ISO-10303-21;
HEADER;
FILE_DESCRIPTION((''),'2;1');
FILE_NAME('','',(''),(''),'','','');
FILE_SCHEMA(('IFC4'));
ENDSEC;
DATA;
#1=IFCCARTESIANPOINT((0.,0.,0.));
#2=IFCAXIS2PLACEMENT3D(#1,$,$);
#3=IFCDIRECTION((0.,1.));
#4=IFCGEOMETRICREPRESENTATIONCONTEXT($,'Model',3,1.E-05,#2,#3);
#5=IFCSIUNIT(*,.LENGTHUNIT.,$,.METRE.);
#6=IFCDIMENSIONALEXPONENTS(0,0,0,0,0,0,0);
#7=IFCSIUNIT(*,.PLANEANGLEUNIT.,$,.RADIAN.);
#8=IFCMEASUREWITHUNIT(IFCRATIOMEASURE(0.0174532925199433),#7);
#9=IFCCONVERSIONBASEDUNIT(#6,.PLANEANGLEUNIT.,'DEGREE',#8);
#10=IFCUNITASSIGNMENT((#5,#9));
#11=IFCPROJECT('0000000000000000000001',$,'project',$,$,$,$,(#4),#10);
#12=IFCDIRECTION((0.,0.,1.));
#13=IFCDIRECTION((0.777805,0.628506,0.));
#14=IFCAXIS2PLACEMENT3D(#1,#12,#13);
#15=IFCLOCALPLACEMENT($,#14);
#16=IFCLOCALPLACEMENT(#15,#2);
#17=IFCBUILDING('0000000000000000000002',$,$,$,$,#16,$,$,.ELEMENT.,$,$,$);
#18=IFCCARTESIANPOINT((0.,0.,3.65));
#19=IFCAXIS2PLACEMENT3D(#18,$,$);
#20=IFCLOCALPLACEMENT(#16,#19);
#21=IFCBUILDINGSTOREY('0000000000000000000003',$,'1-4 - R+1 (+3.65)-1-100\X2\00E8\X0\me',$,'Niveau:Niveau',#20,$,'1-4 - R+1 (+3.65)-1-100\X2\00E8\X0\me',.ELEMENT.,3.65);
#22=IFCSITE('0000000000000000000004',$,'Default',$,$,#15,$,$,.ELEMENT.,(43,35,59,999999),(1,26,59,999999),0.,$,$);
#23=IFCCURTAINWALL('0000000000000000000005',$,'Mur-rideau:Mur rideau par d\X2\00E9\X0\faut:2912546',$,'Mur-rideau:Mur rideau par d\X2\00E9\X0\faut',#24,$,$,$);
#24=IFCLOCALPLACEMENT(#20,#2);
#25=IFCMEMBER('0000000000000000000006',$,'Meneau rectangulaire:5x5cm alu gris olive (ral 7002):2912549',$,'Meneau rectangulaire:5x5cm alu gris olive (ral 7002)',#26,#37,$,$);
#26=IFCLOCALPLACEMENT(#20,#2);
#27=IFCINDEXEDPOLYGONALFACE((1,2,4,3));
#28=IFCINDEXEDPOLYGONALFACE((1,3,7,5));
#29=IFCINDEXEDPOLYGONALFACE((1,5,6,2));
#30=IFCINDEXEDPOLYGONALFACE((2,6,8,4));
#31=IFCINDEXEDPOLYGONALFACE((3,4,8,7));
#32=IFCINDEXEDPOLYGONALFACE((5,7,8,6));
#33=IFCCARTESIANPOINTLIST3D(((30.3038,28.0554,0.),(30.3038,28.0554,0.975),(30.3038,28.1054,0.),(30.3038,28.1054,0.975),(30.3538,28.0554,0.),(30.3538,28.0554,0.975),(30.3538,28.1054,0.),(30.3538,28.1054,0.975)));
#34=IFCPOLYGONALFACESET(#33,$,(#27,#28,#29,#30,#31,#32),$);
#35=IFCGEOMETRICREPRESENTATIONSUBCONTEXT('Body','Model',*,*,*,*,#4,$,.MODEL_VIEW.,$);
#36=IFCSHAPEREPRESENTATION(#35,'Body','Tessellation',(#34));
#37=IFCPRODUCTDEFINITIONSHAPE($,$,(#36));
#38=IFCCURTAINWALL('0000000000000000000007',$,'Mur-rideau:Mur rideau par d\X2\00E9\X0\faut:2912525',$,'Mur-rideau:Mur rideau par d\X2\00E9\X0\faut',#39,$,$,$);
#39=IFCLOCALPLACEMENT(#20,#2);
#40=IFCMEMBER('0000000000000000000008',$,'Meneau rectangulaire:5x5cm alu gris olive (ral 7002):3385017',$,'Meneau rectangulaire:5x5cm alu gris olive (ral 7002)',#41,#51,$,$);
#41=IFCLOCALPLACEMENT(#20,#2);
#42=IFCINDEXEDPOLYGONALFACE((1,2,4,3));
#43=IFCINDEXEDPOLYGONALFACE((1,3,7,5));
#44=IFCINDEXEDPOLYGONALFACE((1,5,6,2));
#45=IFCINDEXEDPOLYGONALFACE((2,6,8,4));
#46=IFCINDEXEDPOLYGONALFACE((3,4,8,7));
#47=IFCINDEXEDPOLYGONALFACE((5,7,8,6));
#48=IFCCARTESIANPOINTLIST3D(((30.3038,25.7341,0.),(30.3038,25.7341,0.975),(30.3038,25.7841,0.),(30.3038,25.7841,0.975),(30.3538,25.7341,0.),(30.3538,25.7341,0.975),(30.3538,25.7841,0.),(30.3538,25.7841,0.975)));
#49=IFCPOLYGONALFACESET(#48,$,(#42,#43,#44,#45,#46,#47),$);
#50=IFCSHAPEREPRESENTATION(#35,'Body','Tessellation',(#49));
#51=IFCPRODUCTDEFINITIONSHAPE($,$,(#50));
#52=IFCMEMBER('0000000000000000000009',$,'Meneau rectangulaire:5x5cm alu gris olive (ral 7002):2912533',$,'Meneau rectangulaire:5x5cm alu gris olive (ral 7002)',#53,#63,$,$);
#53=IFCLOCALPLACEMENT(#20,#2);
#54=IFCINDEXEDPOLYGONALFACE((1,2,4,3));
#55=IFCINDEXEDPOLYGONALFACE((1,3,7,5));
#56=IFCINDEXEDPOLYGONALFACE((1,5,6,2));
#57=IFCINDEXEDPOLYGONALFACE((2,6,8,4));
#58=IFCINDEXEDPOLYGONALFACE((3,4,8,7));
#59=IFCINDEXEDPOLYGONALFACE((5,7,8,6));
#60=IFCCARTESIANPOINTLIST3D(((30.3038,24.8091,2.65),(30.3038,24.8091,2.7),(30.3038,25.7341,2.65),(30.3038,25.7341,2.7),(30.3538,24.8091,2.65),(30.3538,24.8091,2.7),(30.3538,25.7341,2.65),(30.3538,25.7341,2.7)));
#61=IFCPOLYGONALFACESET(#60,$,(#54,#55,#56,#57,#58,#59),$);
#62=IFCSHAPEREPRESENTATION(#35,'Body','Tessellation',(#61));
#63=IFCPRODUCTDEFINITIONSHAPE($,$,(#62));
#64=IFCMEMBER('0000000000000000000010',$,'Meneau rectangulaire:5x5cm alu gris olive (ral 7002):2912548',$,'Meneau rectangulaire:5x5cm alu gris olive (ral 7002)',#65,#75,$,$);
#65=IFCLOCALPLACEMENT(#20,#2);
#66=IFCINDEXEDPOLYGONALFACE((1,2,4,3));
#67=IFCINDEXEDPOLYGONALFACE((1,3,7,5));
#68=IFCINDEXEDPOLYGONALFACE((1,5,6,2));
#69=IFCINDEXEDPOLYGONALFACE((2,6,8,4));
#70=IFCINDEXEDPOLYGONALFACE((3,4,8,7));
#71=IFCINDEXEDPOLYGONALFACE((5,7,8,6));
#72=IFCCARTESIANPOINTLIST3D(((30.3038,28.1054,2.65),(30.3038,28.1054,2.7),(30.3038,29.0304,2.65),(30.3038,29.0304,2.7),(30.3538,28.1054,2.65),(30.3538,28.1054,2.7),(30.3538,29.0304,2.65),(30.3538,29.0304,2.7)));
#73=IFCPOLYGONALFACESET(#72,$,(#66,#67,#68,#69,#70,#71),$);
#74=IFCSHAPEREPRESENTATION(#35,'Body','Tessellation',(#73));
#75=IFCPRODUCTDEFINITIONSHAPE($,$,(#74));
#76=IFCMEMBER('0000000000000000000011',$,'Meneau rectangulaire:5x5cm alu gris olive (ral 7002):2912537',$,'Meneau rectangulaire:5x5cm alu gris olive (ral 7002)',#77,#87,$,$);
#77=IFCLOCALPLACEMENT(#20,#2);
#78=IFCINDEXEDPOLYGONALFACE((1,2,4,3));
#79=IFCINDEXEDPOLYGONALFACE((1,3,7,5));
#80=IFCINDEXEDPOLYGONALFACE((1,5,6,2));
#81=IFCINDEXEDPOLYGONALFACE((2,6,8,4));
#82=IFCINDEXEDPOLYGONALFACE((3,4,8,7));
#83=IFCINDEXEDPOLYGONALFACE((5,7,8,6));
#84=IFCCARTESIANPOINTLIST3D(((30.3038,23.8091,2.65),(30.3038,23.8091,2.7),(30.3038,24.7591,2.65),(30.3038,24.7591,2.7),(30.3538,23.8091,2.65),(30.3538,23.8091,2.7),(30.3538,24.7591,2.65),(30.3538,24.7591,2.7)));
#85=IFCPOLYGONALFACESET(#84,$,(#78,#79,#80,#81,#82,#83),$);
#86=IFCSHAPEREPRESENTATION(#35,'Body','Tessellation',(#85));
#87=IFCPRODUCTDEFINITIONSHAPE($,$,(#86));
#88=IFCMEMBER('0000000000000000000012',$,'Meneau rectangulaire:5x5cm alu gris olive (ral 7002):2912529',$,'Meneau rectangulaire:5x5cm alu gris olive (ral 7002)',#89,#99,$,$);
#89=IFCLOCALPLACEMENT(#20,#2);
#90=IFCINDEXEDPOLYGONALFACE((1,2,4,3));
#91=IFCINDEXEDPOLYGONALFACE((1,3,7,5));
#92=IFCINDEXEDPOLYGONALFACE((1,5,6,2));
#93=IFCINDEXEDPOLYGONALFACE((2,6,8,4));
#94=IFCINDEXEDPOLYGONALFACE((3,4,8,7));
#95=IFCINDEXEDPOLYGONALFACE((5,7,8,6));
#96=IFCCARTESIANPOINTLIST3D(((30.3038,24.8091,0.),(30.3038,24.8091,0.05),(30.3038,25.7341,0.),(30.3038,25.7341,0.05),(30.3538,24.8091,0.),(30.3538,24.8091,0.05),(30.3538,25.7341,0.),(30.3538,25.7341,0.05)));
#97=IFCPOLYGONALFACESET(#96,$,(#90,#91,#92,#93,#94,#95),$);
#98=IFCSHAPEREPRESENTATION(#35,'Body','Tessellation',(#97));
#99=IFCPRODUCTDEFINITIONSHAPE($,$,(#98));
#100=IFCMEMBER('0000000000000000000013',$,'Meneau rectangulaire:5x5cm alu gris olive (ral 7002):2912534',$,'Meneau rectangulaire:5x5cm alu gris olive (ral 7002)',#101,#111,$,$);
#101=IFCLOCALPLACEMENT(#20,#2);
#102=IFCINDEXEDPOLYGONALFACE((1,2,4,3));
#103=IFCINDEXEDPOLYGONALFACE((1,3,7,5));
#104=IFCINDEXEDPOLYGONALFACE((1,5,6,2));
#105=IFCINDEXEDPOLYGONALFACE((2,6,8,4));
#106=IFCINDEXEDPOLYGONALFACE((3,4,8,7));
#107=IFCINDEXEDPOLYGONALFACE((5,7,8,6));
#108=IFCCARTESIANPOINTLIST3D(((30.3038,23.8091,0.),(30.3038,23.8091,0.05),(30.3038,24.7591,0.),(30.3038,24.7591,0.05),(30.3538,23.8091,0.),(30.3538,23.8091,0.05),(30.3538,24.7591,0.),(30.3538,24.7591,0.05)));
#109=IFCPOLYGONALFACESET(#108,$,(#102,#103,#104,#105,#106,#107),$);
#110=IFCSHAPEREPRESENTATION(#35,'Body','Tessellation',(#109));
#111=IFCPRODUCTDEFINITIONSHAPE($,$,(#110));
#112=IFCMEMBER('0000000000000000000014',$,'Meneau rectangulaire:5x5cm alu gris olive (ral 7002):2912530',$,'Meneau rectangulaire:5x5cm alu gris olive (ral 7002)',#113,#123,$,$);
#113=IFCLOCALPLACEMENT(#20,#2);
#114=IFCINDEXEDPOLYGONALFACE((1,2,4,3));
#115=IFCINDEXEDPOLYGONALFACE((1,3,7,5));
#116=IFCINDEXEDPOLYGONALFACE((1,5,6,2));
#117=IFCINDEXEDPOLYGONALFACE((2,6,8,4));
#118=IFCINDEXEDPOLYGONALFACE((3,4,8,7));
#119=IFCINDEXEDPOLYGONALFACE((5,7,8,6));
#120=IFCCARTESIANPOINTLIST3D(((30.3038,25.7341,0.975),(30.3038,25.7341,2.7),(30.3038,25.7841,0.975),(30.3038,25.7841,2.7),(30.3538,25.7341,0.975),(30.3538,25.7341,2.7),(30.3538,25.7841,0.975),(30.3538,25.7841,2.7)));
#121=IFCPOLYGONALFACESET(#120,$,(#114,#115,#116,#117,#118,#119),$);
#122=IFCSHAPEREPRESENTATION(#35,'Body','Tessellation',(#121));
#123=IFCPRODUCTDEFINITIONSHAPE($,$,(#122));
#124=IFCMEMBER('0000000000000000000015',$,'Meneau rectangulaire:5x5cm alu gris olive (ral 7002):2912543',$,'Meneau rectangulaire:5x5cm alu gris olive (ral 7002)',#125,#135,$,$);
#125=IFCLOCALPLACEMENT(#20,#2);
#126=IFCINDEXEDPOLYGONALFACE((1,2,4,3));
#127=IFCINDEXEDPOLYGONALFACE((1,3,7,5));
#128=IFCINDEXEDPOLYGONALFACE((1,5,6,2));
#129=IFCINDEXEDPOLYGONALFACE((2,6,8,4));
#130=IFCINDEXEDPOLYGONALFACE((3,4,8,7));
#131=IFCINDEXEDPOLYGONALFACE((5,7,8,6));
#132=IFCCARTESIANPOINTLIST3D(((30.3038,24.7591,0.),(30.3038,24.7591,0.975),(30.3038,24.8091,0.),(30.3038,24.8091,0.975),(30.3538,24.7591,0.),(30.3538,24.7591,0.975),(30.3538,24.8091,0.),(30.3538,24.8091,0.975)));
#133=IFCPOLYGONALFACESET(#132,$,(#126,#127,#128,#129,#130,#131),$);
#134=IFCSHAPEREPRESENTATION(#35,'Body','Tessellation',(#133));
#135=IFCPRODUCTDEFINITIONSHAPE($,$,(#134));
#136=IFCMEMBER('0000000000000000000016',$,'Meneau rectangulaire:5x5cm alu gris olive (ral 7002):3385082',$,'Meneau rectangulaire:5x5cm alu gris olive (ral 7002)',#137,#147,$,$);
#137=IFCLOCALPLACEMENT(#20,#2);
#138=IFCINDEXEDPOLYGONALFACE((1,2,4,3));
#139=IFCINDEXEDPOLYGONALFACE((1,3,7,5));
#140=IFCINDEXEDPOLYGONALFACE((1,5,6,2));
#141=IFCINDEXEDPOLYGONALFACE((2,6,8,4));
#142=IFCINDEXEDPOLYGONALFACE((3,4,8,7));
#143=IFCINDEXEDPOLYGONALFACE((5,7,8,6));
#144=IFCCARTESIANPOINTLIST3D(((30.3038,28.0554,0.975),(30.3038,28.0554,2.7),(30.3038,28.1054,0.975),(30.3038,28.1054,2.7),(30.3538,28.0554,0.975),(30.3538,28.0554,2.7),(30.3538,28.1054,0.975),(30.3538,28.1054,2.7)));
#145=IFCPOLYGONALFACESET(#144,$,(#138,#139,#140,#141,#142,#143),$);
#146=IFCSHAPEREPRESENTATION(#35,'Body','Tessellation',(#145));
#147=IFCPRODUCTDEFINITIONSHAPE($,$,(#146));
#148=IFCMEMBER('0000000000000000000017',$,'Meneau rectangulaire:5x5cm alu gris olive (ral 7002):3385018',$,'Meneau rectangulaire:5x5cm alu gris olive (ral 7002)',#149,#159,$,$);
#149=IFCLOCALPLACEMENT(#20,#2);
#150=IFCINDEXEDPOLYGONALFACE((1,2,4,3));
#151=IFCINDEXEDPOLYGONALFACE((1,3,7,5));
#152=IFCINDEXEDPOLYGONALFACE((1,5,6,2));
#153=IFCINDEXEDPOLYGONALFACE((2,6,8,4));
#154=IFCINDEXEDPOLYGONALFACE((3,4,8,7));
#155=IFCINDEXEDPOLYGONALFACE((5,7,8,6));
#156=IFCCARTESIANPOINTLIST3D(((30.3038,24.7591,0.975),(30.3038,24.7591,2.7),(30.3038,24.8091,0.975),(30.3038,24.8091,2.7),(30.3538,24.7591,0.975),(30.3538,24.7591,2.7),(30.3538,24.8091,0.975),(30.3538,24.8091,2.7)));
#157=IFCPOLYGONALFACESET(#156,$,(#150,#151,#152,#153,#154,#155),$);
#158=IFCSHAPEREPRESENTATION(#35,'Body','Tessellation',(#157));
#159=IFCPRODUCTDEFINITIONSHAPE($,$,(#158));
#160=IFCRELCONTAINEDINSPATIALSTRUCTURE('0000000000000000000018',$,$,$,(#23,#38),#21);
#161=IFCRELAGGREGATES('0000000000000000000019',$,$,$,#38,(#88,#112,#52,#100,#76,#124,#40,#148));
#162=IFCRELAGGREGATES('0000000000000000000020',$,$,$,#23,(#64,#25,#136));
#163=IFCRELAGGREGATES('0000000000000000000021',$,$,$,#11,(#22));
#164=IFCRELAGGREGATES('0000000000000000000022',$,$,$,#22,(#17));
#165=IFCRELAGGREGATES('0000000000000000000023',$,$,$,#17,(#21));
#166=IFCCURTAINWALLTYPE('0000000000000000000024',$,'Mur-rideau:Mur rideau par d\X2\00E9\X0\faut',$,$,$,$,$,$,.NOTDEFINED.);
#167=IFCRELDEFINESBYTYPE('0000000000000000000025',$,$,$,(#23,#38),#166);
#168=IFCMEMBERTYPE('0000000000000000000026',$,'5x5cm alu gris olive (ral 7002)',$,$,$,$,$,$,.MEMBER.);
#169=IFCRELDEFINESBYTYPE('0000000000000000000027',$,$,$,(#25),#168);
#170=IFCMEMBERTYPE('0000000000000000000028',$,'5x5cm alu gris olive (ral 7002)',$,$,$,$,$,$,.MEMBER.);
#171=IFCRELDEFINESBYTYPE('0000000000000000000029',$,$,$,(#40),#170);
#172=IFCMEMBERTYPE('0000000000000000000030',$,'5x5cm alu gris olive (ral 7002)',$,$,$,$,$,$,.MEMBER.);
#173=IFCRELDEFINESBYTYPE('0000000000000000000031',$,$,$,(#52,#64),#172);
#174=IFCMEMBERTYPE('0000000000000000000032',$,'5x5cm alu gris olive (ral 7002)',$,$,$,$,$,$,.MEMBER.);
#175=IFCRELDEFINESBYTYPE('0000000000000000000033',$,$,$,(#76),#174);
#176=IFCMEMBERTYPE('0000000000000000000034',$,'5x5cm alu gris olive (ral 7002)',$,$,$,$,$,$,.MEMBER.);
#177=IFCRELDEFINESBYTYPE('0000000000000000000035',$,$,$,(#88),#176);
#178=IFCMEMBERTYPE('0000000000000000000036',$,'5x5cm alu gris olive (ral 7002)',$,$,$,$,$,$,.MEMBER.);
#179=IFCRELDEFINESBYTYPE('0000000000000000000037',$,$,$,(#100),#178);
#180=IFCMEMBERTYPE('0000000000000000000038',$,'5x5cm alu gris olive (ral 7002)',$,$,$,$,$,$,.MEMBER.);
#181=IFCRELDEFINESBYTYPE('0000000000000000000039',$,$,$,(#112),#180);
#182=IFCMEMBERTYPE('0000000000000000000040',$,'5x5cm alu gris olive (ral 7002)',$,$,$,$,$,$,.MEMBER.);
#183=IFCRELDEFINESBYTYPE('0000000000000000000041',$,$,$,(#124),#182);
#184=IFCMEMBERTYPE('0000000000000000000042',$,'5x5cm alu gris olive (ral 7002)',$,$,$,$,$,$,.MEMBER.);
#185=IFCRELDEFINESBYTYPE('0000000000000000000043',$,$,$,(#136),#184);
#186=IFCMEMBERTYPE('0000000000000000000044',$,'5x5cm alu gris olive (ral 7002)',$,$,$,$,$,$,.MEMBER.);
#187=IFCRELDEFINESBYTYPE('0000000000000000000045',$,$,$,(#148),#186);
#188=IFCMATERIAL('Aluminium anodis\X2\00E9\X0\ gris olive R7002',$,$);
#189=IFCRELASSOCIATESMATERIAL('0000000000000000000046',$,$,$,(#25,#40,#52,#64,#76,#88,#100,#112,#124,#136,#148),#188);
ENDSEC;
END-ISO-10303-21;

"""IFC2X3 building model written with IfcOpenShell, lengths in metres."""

from ifc_helpers import new_model, entity, si_unit, converted_unit, direction, frame, origin, origin_2d_with_axis, place, context, subcontext, project, spatial, rectangle, extrude, source, transform, mapped, material, type_object, type_shapes, element, aggregate, save


model = new_model("IFC2X3")

# Units and contexts
model_context = context("Model", 3, precision=1e-05, world=origin(), true_north=direction((0.0, 1.0)))
body_context = subcontext(model_context, "Body", "Model", "MODEL_VIEW")
ifc_project = project(units=[si_unit("LENGTHUNIT", "METRE"), converted_unit("PLANEANGLEUNIT", "DEGREE", entity("IfcRatioMeasure", 0.0174532925199433), si_unit("PLANEANGLEUNIT", "RADIAN"), dimensions=[0, 0, 0, 0, 0, 0, 0])], contexts=[model_context])

# Site, building, storey
site_placement = place(None, frame((0.0, 0.0, 0.0), z_axis=(0.0, 0.0, 1.0), x_axis=(0.777805, 0.628506, 0.0)))
site = spatial("IfcSite", under=ifc_project, at=site_placement, Name="Default", CompositionType="ELEMENT", RefLatitude=(43, 35, 59, 999999), RefLongitude=(1, 26, 59, 999999), RefElevation=0.0)
building_placement = place(site_placement, origin())
building = spatial("IfcBuilding", under=site, at=building_placement, CompositionType="ELEMENT")
storey_placement = place(building_placement, frame((0.0, 0.0, 3.65)))
storey = spatial("IfcBuildingStorey", under=building, at=storey_placement, Name="1-4 - R+1 (+3.65)-1-100ème", ObjectType="Niveau:Niveau", LongName="1-4 - R+1 (+3.65)-1-100ème", CompositionType="ELEMENT", Elevation=3.65)

# Curtain wall, member
curtain_wall_type = type_object("IfcCurtainWallType", Name="Mur-rideau:Mur rideau par défaut", PredefinedType="NOTDEFINED")
curtain_wall_1_placement = place(storey_placement, frame((0.0, 0.0, -3.65)))
curtain_wall_1 = element("IfcCurtainWall", 1, at=curtain_wall_1_placement, inside=storey, type_object=curtain_wall_type, Name="Mur-rideau:Mur rideau par défaut:2912546", ObjectType="Mur-rideau:Mur rideau par défaut")
ifc_material_1 = material(Name="Aluminium anodisé gris olive R7002")
member_type_1 = type_object("IfcMemberType", Name="5x5cm alu gris olive (ral 7002)", PredefinedType="MEMBER")
shared_shape_1 = source(origin(), body_context, "Body", "SweptSolid", [
    extrude(rectangle(XDim=0.05, YDim=0.05, at=origin_2d_with_axis()), frame((-0.025, 0.0, -0.975), z_axis=(0.0, 0.0, 1.0), x_axis=(0.0, -1.0, 0.0)), (0.0, 0.0, 1.0), 0.975),
])
type_shapes(member_type_1, [shared_shape_1])
member_1_placement = place(storey_placement, frame((30.3288, 28.0554, 0.0), z_axis=(0.0, 0.0, -1.0), x_axis=(0.0, -1.0, 0.0)))
member_1 = element("IfcMember", 2, at=member_1_placement, type_object=member_type_1, material=ifc_material_1, Name="Meneau rectangulaire:5x5cm alu gris olive (ral 7002):2912549", ObjectType="Meneau rectangulaire:5x5cm alu gris olive (ral 7002)", context=body_context, shape_type="MappedRepresentation", body=[
    mapped(shared_shape_1, transform((0.0, 0.0, 0.0), scale=1.0)),
])

# Curtain wall, members
curtain_wall_2_placement = place(storey_placement, frame((0.0, 0.0, -3.65)))
curtain_wall_2 = element("IfcCurtainWall", 3, at=curtain_wall_2_placement, inside=storey, type_object=curtain_wall_type, Name="Mur-rideau:Mur rideau par défaut:2912525", ObjectType="Mur-rideau:Mur rideau par défaut")
member_type_2 = type_object("IfcMemberType", Name="5x5cm alu gris olive (ral 7002)", PredefinedType="MEMBER")
shared_shape_2 = source(origin(), body_context, "Body", "SweptSolid", [
    extrude(rectangle(XDim=0.05, YDim=0.05, at=origin_2d_with_axis()), frame((-0.025, 0.0, -0.975), z_axis=(0.0, 0.0, 1.0), x_axis=(0.0, -1.0, 0.0)), (0.0, 0.0, 1.0), 0.975),
])
type_shapes(member_type_2, [shared_shape_2])
member_2_placement = place(storey_placement, frame((30.3288, 25.7841, 0.975), z_axis=(0.0, 0.0, 1.0), x_axis=(0.0, 1.0, 0.0)))
member_2 = element("IfcMember", 4, at=member_2_placement, type_object=member_type_2, material=ifc_material_1, Name="Meneau rectangulaire:5x5cm alu gris olive (ral 7002):3385017", ObjectType="Meneau rectangulaire:5x5cm alu gris olive (ral 7002)", context=body_context, shape_type="MappedRepresentation", body=[
    mapped(shared_shape_2, transform((0.0, 0.0, 0.0), scale=1.0)),
])
member_type_3 = type_object("IfcMemberType", Name="5x5cm alu gris olive (ral 7002)", PredefinedType="MEMBER")
shared_shape_3 = source(origin(), body_context, "Body", "SweptSolid", [
    extrude(rectangle(XDim=0.05, YDim=0.05, at=origin_2d_with_axis()), frame((-0.025, 0.0, -0.925), z_axis=(0.0, 0.0, 1.0), x_axis=(0.0, -1.0, 0.0)), (0.0, 0.0, 1.0), 0.925),
])
type_shapes(member_type_3, [shared_shape_3])
member_3_placement = place(storey_placement, frame((30.3288, 24.8091, 2.7), z_axis=(0.0, -1.0, 0.0), x_axis=(0.0, 0.0, 1.0)))
member_3 = element("IfcMember", 5, at=member_3_placement, type_object=member_type_3, material=ifc_material_1, Name="Meneau rectangulaire:5x5cm alu gris olive (ral 7002):2912533", ObjectType="Meneau rectangulaire:5x5cm alu gris olive (ral 7002)", context=body_context, shape_type="MappedRepresentation", body=[
    mapped(shared_shape_3, transform((0.0, 0.0, 0.0), scale=1.0)),
])

# Members
member_4_placement = place(storey_placement, frame((30.3288, 28.1054, 2.7), z_axis=(0.0, -1.0, 0.0), x_axis=(0.0, 0.0, 1.0)))
member_4 = element("IfcMember", 6, at=member_4_placement, type_object=member_type_3, material=ifc_material_1, Name="Meneau rectangulaire:5x5cm alu gris olive (ral 7002):2912548", ObjectType="Meneau rectangulaire:5x5cm alu gris olive (ral 7002)", context=body_context, shape_type="MappedRepresentation", body=[
    mapped(shared_shape_3, transform((0.0, 0.0, 0.0), scale=1.0)),
])
member_type_4 = type_object("IfcMemberType", Name="5x5cm alu gris olive (ral 7002)", PredefinedType="MEMBER")
shared_shape_4 = source(origin(), body_context, "Body", "SweptSolid", [
    extrude(rectangle(XDim=0.05, YDim=0.05, at=origin_2d_with_axis()), frame((-0.025, 0.0, -0.95), z_axis=(0.0, 0.0, 1.0), x_axis=(0.0, -1.0, 0.0)), (0.0, 0.0, 1.0), 0.95),
])
type_shapes(member_type_4, [shared_shape_4])
member_5_placement = place(storey_placement, frame((30.3288, 23.8091, 2.7), z_axis=(0.0, -1.0, 0.0), x_axis=(0.0, 0.0, 1.0)))
member_5 = element("IfcMember", 7, at=member_5_placement, type_object=member_type_4, material=ifc_material_1, Name="Meneau rectangulaire:5x5cm alu gris olive (ral 7002):2912537", ObjectType="Meneau rectangulaire:5x5cm alu gris olive (ral 7002)", context=body_context, shape_type="MappedRepresentation", body=[
    mapped(shared_shape_4, transform((0.0, 0.0, 0.0), scale=1.0)),
])
member_type_5 = type_object("IfcMemberType", Name="5x5cm alu gris olive (ral 7002)", PredefinedType="MEMBER")
shared_shape_5 = source(origin(), body_context, "Body", "SweptSolid", [
    extrude(rectangle(XDim=0.05, YDim=0.05, at=origin_2d_with_axis()), frame((-0.025, 0.0, -0.925), z_axis=(0.0, 0.0, 1.0), x_axis=(0.0, -1.0, 0.0)), (0.0, 0.0, 1.0), 0.925),
])
type_shapes(member_type_5, [shared_shape_5])
member_6_placement = place(storey_placement, frame((30.3288, 25.7341, 0.0), z_axis=(0.0, 1.0, 0.0), x_axis=(0.0, 0.0, -1.0)))
member_6 = element("IfcMember", 8, at=member_6_placement, type_object=member_type_5, material=ifc_material_1, Name="Meneau rectangulaire:5x5cm alu gris olive (ral 7002):2912529", ObjectType="Meneau rectangulaire:5x5cm alu gris olive (ral 7002)", context=body_context, shape_type="MappedRepresentation", body=[
    mapped(shared_shape_5, transform((0.0, 0.0, 0.0), scale=1.0)),
])
member_type_6 = type_object("IfcMemberType", Name="5x5cm alu gris olive (ral 7002)", PredefinedType="MEMBER")
shared_shape_6 = source(origin(), body_context, "Body", "SweptSolid", [
    extrude(rectangle(XDim=0.05, YDim=0.05, at=origin_2d_with_axis()), frame((-0.025, 0.0, -0.95), z_axis=(0.0, 0.0, 1.0), x_axis=(0.0, -1.0, 0.0)), (0.0, 0.0, 1.0), 0.95),
])
type_shapes(member_type_6, [shared_shape_6])
member_7_placement = place(storey_placement, frame((30.3288, 24.7591, 0.0), z_axis=(0.0, 1.0, 0.0), x_axis=(0.0, 0.0, -1.0)))
member_7 = element("IfcMember", 9, at=member_7_placement, type_object=member_type_6, material=ifc_material_1, Name="Meneau rectangulaire:5x5cm alu gris olive (ral 7002):2912534", ObjectType="Meneau rectangulaire:5x5cm alu gris olive (ral 7002)", context=body_context, shape_type="MappedRepresentation", body=[
    mapped(shared_shape_6, transform((0.0, 0.0, 0.0), scale=1.0)),
])
member_type_7 = type_object("IfcMemberType", Name="5x5cm alu gris olive (ral 7002)", PredefinedType="MEMBER")
shared_shape_7 = source(origin(), body_context, "Body", "SweptSolid", [
    extrude(rectangle(XDim=0.05, YDim=0.05, at=origin_2d_with_axis()), frame((-0.025, 0.0, -1.725), z_axis=(0.0, 0.0, 1.0), x_axis=(0.0, -1.0, 0.0)), (0.0, 0.0, 1.0), 1.725),
])
type_shapes(member_type_7, [shared_shape_7])
member_8_placement = place(storey_placement, frame((30.3288, 25.7841, 2.7), z_axis=(0.0, 0.0, 1.0), x_axis=(0.0, 1.0, 0.0)))
member_8 = element("IfcMember", 10, at=member_8_placement, type_object=member_type_7, material=ifc_material_1, Name="Meneau rectangulaire:5x5cm alu gris olive (ral 7002):2912530", ObjectType="Meneau rectangulaire:5x5cm alu gris olive (ral 7002)", context=body_context, shape_type="MappedRepresentation", body=[
    mapped(shared_shape_7, transform((0.0, 0.0, 0.0), scale=1.0)),
])
member_type_8 = type_object("IfcMemberType", Name="5x5cm alu gris olive (ral 7002)", PredefinedType="MEMBER")
shared_shape_8 = source(origin(), body_context, "Body", "SweptSolid", [
    extrude(rectangle(XDim=0.05, YDim=0.05, at=origin_2d_with_axis()), frame((0.0, 0.0, -0.975), z_axis=(0.0, 0.0, 1.0), x_axis=(0.0, -1.0, 0.0)), (0.0, 0.0, 1.0), 0.975),
])
type_shapes(member_type_8, [shared_shape_8])
member_9_placement = place(storey_placement, frame((30.3288, 24.7841, 0.0), z_axis=(0.0, 0.0, -1.0), x_axis=(0.0, -1.0, 0.0)))
member_9 = element("IfcMember", 11, at=member_9_placement, type_object=member_type_8, material=ifc_material_1, Name="Meneau rectangulaire:5x5cm alu gris olive (ral 7002):2912543", ObjectType="Meneau rectangulaire:5x5cm alu gris olive (ral 7002)", context=body_context, shape_type="MappedRepresentation", body=[
    mapped(shared_shape_8, transform((0.0, 0.0, 0.0), scale=1.0)),
])
member_type_9 = type_object("IfcMemberType", Name="5x5cm alu gris olive (ral 7002)", PredefinedType="MEMBER")
shared_shape_9 = source(origin(), body_context, "Body", "SweptSolid", [
    extrude(rectangle(XDim=0.05, YDim=0.05, at=origin_2d_with_axis()), frame((-0.025, 0.0, -1.725), z_axis=(0.0, 0.0, 1.0), x_axis=(0.0, -1.0, 0.0)), (0.0, 0.0, 1.0), 1.725),
])
type_shapes(member_type_9, [shared_shape_9])
member_10_placement = place(storey_placement, frame((30.3288, 28.0554, 0.975), z_axis=(0.0, 0.0, -1.0), x_axis=(0.0, -1.0, 0.0)))
member_10 = element("IfcMember", 12, at=member_10_placement, type_object=member_type_9, material=ifc_material_1, Name="Meneau rectangulaire:5x5cm alu gris olive (ral 7002):3385082", ObjectType="Meneau rectangulaire:5x5cm alu gris olive (ral 7002)", context=body_context, shape_type="MappedRepresentation", body=[
    mapped(shared_shape_9, transform((0.0, 0.0, 0.0), scale=1.0)),
])
member_type_10 = type_object("IfcMemberType", Name="5x5cm alu gris olive (ral 7002)", PredefinedType="MEMBER")
shared_shape_10 = source(origin(), body_context, "Body", "SweptSolid", [
    extrude(rectangle(XDim=0.05, YDim=0.05, at=origin_2d_with_axis()), frame((0.0, 0.0, -1.725), z_axis=(0.0, 0.0, 1.0), x_axis=(0.0, -1.0, 0.0)), (0.0, 0.0, 1.0), 1.725),
])
type_shapes(member_type_10, [shared_shape_10])
member_11_placement = place(storey_placement, frame((30.3288, 24.7841, 0.975), z_axis=(0.0, 0.0, -1.0), x_axis=(0.0, -1.0, 0.0)))
member_11 = element("IfcMember", 13, at=member_11_placement, type_object=member_type_10, material=ifc_material_1, Name="Meneau rectangulaire:5x5cm alu gris olive (ral 7002):3385018", ObjectType="Meneau rectangulaire:5x5cm alu gris olive (ral 7002)", context=body_context, shape_type="MappedRepresentation", body=[
    mapped(shared_shape_10, transform((0.0, 0.0, 0.0), scale=1.0)),
])

aggregate(curtain_wall_2, [member_6, member_8, member_3, member_7, member_5, member_9, member_2, member_11])
aggregate(curtain_wall_1, [member_4, member_1, member_10])

save(model, "model.ifc")
